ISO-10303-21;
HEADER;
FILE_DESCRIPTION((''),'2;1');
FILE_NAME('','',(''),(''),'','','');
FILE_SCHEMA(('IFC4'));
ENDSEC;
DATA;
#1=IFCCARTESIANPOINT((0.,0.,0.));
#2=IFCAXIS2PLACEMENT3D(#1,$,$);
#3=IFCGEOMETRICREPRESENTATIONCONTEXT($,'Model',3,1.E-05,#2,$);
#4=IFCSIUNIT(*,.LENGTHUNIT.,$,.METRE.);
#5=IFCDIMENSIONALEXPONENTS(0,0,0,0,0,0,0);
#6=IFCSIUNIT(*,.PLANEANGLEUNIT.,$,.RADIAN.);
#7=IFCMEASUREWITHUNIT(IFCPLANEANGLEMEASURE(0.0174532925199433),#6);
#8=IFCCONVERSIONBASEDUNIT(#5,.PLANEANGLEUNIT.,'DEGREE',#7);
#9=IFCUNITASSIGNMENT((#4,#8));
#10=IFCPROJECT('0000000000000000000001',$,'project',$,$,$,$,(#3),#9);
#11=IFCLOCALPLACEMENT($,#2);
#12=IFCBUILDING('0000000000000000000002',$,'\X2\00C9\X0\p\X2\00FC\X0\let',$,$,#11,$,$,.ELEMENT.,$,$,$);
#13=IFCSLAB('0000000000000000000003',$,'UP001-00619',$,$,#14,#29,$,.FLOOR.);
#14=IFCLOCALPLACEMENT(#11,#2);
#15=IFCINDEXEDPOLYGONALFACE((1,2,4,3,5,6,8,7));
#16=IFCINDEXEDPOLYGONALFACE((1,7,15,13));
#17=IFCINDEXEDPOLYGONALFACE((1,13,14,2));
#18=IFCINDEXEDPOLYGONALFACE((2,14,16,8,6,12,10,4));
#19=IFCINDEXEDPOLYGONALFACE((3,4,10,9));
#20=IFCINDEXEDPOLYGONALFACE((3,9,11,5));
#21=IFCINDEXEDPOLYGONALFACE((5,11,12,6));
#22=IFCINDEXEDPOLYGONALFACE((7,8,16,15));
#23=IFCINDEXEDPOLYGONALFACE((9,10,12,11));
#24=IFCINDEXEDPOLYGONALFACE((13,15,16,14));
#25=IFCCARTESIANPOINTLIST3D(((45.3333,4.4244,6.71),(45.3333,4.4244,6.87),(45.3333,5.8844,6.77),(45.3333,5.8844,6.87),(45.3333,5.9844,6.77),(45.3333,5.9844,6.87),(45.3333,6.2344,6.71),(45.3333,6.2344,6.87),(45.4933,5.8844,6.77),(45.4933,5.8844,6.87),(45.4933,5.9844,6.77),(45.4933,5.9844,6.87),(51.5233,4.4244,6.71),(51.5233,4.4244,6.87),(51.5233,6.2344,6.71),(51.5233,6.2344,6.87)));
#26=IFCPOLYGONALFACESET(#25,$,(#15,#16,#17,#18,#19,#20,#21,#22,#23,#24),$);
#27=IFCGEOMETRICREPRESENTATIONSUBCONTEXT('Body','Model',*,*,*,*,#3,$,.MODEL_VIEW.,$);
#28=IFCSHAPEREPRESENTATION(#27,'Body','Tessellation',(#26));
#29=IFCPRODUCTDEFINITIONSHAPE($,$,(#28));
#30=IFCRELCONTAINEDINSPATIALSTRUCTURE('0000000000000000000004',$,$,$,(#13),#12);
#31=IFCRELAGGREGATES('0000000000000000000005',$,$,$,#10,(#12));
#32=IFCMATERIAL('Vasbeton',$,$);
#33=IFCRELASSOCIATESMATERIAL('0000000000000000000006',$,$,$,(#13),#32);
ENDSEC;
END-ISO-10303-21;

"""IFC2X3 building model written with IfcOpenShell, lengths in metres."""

from ifc_helpers import new_model, entity, si_unit, converted_unit, frame, frame_2d, origin, place, context, subcontext, project, spatial, rectangle, extrude, material, element, save


model = new_model("IFC2X3")

# Units and contexts
model_context = context("Model", 3, precision=1e-05, world=origin())
body_context = subcontext(model_context, "Body", "Model", "MODEL_VIEW")
ifc_project = project(units=[si_unit("LENGTHUNIT", "METRE"), converted_unit("PLANEANGLEUNIT", "DEGREE", entity("IfcPlaneAngleMeasure", 0.0174532925199433), si_unit("PLANEANGLEUNIT", "RADIAN"), dimensions=[0, 0, 0, 0, 0, 0, 0])], contexts=[model_context])

# Building
building_placement = place(None, origin())
building = spatial("IfcBuilding", under=ifc_project, at=building_placement, Name="Épület", CompositionType="ELEMENT")

# Slab, opening
ifc_material = material(Name="Vasbeton")
slab_placement = place(building_placement, frame((45.3333, 4.4244, 6.71)))
slab = element("IfcSlab", 1, at=slab_placement, inside=building, material=ifc_material, Name="UP001-00619", PredefinedType="FLOOR", context=body_context, shape_type="SweptSolid", body=[
    extrude(rectangle(XDim=1.81, YDim=6.19, at=frame_2d((3.095, -0.905), x_axis=(0.0, -1.0))), frame((0.0, 1.81, 0.0), z_axis=(0.0, 0.0, 1.0), x_axis=(1.0, 0.0, 0.0)), (0.0, 0.0, 1.0), 0.16),
])
opening_placement = place(slab_placement, frame((0.0, 1.46, 0.06)))
element("IfcOpeningElement", 2, at=opening_placement, cuts=slab, ObjectType="Recess", context=body_context, shape_type="SweptSolid", body=[
    extrude(rectangle(XDim=0.16, YDim=0.1, at=frame_2d((0.0, 0.0), x_axis=(-1.0, 0.0))), frame((0.08, 0.05, 0.0), z_axis=(0.0, 0.0, 1.0), x_axis=(1.0, 0.0, 0.0)), (0.0, 0.0, 1.0), 0.1),
])

save(model, "model.ifc")
